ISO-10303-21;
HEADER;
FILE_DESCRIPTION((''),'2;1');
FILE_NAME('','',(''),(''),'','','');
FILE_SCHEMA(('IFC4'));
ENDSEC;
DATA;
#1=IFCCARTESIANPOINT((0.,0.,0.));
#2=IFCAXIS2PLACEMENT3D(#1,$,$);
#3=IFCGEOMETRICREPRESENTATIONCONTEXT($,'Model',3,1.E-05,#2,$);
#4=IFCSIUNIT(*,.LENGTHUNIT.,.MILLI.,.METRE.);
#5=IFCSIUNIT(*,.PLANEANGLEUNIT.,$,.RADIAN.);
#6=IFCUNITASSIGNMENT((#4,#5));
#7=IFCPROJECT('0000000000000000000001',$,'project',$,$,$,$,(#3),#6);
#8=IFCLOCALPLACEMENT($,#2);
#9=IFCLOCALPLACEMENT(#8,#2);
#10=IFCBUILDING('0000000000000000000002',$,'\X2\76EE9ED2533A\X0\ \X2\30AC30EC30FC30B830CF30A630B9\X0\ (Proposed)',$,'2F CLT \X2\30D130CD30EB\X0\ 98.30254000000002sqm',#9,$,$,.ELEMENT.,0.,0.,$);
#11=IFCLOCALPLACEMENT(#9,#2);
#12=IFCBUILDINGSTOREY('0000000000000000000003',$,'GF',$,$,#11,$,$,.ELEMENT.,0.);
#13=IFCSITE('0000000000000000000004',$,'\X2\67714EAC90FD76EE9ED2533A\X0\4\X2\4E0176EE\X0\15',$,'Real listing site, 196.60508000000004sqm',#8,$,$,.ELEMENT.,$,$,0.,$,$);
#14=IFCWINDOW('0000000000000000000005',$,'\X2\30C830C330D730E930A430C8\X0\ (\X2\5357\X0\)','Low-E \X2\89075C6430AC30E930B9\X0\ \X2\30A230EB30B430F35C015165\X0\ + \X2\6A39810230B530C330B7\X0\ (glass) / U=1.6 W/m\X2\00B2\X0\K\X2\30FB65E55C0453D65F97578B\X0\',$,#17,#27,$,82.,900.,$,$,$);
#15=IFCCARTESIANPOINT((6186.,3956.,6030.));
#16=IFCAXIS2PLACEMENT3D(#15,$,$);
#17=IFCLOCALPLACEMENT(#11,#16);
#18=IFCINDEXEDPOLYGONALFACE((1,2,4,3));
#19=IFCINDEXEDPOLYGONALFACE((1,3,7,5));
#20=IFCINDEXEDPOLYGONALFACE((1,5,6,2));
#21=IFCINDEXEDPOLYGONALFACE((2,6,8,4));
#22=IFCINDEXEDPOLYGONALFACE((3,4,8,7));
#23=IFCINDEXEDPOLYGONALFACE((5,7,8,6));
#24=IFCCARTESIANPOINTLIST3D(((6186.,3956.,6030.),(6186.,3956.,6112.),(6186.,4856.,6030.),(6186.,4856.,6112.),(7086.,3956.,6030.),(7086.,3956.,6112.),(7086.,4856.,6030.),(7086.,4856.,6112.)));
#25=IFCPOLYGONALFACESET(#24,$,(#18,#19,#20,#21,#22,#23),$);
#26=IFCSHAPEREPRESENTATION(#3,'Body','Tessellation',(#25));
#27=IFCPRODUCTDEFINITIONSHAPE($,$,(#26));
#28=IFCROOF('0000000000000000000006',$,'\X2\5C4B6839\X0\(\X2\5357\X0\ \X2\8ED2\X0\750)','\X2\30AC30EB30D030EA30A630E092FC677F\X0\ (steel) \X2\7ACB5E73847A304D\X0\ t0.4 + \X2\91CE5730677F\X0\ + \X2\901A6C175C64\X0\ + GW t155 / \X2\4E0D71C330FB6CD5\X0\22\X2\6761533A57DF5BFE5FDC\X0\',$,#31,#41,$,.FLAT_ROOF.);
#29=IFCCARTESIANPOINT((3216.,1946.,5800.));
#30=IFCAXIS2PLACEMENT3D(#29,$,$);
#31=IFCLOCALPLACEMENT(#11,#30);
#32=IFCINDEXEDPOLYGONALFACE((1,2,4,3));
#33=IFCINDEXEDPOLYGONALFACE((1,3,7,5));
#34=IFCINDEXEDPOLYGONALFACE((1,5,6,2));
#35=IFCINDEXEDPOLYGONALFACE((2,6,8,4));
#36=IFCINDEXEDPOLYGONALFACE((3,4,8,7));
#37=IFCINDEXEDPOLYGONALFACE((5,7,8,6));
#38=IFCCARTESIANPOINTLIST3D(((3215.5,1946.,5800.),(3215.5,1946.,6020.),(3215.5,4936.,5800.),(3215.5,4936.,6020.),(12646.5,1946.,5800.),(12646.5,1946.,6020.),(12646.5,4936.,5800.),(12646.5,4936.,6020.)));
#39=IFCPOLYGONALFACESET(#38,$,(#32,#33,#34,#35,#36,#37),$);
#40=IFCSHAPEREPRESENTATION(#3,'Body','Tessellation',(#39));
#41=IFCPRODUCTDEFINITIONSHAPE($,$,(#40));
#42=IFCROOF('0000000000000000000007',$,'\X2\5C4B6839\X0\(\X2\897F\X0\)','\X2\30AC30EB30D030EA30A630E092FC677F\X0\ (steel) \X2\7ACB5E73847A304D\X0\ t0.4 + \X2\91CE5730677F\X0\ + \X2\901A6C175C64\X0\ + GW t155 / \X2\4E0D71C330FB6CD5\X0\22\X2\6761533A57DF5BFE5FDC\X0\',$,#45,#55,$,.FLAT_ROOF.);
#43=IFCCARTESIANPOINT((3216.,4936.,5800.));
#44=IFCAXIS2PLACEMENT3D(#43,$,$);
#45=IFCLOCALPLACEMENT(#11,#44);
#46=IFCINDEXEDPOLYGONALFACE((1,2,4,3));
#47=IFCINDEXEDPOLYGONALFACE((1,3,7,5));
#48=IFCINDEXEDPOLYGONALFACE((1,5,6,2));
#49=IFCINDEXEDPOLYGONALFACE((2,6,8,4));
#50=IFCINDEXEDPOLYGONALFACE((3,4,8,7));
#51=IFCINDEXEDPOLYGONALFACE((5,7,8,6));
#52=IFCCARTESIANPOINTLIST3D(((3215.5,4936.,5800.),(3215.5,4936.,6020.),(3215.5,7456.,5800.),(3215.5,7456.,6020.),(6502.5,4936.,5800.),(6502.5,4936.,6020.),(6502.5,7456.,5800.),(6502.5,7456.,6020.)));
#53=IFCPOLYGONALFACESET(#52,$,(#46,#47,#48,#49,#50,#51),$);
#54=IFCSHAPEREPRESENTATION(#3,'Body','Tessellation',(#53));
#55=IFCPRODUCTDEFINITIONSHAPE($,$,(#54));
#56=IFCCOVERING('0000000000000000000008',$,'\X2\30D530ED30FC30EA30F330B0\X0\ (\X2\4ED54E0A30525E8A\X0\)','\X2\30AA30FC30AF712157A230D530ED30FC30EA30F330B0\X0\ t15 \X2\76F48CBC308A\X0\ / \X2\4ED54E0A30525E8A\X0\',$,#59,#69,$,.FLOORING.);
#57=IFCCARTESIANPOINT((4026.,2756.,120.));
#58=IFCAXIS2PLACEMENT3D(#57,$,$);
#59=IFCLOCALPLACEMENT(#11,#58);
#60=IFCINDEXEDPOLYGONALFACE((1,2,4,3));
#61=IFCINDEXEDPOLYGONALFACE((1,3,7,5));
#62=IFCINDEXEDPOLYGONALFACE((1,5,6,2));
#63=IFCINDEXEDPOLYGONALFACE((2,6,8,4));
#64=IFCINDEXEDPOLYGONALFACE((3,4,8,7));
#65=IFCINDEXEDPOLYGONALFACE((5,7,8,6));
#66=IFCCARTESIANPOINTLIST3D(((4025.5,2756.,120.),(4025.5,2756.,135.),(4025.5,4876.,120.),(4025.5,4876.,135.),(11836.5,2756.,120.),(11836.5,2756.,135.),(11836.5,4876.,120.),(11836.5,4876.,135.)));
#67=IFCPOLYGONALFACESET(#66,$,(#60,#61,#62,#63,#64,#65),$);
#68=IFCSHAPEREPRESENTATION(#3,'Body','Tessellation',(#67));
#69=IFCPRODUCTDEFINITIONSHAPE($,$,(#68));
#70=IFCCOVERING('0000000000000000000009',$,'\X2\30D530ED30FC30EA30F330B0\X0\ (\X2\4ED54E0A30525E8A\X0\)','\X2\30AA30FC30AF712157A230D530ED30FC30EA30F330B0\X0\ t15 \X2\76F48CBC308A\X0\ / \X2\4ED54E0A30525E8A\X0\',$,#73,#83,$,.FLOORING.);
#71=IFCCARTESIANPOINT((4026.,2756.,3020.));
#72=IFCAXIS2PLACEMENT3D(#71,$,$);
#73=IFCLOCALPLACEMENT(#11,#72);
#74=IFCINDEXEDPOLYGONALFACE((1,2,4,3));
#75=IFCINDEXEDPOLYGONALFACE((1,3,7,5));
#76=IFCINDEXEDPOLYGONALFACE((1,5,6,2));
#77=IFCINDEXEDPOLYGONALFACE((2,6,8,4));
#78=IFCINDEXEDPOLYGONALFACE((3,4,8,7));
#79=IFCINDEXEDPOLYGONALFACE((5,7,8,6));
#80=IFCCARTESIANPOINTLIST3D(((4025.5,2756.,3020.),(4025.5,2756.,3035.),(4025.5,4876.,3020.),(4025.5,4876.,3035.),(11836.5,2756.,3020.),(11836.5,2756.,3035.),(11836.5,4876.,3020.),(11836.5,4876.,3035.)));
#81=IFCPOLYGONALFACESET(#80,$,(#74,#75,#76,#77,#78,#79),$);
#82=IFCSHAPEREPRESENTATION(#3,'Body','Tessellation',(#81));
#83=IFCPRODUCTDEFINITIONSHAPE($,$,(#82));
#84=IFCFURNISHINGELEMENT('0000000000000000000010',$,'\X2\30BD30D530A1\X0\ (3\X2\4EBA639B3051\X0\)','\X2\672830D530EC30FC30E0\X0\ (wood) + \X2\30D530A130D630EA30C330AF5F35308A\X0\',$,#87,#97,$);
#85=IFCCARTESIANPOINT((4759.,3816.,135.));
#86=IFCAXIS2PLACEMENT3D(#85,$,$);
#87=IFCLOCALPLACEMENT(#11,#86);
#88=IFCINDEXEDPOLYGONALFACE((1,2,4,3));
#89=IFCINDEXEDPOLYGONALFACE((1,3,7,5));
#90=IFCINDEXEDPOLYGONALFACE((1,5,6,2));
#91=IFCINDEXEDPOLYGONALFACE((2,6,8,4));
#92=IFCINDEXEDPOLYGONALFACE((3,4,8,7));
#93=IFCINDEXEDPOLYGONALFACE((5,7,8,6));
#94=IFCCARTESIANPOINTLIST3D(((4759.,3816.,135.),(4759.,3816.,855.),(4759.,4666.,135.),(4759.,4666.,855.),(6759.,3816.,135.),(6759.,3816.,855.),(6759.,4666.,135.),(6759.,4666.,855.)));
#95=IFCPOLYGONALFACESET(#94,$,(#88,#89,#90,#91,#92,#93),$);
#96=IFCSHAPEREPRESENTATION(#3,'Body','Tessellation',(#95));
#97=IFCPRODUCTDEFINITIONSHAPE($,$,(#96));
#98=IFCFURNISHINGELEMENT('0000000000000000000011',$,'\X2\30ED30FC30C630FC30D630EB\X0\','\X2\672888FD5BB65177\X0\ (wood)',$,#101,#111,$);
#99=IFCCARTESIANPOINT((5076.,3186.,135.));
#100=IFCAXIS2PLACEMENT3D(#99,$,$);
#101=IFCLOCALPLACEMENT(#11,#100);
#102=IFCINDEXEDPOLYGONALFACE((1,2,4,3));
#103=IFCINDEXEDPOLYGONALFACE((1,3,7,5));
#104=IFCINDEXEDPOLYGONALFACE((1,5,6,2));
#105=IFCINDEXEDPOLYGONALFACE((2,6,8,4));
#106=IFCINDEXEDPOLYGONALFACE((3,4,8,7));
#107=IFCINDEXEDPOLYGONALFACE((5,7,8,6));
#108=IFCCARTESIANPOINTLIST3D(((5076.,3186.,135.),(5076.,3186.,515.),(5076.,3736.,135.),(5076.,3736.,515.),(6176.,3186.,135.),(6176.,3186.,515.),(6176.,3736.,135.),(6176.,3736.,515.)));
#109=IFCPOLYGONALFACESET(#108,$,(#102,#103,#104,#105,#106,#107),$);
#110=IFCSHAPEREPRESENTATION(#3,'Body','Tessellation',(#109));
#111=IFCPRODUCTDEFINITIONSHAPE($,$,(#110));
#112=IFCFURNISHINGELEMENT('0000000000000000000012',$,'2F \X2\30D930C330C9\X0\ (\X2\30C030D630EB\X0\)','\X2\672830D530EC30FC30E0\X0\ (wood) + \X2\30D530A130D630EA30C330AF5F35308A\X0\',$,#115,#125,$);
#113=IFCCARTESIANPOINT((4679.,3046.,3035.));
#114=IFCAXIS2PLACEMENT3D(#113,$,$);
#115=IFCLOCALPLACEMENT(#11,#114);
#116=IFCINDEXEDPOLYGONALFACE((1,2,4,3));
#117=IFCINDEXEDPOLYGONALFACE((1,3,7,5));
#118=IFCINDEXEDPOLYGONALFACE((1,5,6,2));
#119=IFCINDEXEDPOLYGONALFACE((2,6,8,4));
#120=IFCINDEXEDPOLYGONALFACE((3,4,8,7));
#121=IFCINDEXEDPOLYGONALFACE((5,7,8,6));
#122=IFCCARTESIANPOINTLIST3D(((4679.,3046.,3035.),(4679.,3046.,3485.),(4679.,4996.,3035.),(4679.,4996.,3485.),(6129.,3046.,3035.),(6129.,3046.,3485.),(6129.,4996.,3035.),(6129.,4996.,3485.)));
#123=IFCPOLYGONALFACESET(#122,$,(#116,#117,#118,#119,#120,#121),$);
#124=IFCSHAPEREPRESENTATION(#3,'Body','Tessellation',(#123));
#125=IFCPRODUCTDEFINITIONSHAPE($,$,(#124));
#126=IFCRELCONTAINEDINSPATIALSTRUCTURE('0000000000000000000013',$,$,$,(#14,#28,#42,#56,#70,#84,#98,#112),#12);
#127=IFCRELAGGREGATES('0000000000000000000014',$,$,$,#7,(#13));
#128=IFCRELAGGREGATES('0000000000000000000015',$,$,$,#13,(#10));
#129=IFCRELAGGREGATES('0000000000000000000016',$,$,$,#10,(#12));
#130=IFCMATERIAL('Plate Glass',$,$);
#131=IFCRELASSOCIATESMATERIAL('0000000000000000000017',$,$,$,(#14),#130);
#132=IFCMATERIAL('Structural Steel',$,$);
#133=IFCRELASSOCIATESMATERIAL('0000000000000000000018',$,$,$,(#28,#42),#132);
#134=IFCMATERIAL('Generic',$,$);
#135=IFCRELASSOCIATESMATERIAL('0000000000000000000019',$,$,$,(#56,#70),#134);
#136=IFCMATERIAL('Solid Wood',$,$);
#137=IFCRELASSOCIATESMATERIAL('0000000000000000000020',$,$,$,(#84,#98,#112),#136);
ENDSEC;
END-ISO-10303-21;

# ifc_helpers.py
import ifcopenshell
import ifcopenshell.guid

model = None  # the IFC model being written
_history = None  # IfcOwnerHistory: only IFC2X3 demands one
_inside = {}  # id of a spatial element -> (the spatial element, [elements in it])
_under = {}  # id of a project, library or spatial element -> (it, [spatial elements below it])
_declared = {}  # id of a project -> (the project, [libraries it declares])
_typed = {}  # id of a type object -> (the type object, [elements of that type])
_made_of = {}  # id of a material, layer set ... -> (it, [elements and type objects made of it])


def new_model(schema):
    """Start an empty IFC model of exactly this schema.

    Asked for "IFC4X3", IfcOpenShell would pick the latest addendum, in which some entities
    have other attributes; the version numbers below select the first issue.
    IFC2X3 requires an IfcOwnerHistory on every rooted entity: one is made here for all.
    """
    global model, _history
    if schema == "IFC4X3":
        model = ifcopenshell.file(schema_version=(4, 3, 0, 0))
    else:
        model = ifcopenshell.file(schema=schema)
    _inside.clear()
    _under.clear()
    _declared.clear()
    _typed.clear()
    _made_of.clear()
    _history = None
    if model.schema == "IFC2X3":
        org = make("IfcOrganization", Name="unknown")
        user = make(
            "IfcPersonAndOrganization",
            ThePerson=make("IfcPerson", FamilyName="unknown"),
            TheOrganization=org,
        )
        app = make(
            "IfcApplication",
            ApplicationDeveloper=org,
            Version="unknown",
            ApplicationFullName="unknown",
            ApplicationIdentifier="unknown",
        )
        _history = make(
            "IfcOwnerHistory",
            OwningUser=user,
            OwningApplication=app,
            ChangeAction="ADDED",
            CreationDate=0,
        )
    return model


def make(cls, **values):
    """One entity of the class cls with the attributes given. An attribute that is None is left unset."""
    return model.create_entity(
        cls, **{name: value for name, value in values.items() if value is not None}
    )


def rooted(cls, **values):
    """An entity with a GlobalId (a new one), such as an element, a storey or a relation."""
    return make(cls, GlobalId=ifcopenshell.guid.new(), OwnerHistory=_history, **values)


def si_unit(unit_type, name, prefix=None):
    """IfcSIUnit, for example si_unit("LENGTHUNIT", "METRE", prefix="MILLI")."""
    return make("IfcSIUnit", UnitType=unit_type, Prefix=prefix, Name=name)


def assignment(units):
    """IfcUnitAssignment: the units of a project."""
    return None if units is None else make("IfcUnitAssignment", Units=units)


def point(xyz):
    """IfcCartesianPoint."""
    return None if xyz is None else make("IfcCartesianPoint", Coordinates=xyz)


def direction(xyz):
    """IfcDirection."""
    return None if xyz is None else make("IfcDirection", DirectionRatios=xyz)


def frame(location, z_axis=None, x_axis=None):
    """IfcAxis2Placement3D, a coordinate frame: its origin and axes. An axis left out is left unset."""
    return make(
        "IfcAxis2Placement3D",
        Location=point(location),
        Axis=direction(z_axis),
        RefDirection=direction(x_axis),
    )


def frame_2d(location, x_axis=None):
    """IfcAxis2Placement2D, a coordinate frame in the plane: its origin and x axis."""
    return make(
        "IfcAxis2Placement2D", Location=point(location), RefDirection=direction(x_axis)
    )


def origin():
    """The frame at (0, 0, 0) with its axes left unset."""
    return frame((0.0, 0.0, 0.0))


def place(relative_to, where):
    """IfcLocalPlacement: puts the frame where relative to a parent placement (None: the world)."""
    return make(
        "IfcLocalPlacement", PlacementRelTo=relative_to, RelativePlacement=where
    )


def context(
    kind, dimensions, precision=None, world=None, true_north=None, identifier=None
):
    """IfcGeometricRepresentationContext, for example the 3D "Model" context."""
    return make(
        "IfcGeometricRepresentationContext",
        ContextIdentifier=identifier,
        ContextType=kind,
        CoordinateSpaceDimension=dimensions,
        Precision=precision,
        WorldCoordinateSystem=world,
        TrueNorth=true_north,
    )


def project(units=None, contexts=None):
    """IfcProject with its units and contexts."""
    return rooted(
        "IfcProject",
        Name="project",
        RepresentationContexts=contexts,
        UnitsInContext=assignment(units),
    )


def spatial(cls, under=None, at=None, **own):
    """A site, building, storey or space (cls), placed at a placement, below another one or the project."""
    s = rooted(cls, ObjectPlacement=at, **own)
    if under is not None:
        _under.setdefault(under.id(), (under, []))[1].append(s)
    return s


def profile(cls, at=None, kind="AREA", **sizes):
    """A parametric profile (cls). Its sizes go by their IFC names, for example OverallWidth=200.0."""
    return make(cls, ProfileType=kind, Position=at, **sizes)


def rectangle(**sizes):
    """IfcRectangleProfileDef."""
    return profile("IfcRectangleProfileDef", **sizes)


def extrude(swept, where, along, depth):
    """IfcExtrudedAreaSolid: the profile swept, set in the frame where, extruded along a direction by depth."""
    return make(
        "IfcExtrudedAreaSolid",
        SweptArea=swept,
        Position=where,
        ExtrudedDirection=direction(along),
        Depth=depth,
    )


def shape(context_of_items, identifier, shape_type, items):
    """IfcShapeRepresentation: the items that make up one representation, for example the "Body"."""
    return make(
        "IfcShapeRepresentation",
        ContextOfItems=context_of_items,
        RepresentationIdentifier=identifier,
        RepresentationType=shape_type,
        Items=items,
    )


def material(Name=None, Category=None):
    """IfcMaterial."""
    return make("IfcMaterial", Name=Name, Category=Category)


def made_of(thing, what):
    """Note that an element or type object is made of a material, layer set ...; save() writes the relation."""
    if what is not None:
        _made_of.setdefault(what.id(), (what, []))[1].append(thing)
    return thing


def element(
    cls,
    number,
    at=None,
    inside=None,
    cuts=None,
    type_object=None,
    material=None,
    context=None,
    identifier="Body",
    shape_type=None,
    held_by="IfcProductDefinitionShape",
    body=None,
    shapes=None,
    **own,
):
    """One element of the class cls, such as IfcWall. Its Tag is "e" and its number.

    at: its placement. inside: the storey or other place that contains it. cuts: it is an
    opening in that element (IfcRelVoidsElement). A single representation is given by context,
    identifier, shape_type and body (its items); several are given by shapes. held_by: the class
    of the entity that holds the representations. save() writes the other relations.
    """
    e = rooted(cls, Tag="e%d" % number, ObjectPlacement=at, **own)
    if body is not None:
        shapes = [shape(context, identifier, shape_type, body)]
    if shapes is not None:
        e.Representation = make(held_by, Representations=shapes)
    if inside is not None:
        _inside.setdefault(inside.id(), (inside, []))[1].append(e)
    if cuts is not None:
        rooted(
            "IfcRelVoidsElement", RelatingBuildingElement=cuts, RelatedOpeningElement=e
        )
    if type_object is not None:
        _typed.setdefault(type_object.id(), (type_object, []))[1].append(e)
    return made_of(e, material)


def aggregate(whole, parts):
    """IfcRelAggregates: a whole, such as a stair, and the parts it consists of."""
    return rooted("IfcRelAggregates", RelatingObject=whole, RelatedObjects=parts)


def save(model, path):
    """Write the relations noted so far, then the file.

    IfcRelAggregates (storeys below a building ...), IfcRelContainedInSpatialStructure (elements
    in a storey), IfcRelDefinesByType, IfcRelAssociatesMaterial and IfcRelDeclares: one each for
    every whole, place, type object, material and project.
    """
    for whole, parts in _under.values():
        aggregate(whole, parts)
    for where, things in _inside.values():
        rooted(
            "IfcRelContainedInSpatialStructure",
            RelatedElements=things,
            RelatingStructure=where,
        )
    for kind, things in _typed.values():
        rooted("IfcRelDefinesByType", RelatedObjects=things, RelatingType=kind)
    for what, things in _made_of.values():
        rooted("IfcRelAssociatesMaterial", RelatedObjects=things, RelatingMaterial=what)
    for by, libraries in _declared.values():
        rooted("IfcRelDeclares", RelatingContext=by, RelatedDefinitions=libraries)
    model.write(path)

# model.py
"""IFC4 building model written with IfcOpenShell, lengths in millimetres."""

from ifc_helpers import new_model, si_unit, frame, frame_2d, origin, place, context, project, spatial, rectangle, extrude, material, element, save


model = new_model("IFC4")

# Units and contexts
model_context = context("Model", 3, precision=1e-05, world=origin())
ifc_project = project(units=[si_unit("LENGTHUNIT", "METRE", prefix="MILLI"), si_unit("PLANEANGLEUNIT", "RADIAN")], contexts=[model_context])

# Site, building, storey
site_placement = place(None, origin())
site = spatial("IfcSite", under=ifc_project, at=site_placement, Name="東京都目黒区4丁目15", ObjectType="Real listing site, 196.60508000000004sqm", CompositionType="ELEMENT", RefElevation=0.0)
building_placement = place(site_placement, origin())
building = spatial("IfcBuilding", under=site, at=building_placement, Name="目黒区 ガレージハウス (Proposed)", ObjectType="2F CLT パネル 98.30254000000002sqm", CompositionType="ELEMENT", ElevationOfRefHeight=0.0, ElevationOfTerrain=0.0)
storey_placement = place(building_placement, origin())
storey = spatial("IfcBuildingStorey", under=building, at=storey_placement, Name="GF", CompositionType="ELEMENT", Elevation=0.0)

# Shared definitions
ifc_material_1 = material(Name="Solid Wood")

# Shared definitions
ifc_material_2 = material(Name="Plate Glass")

# Window
window_1_placement = place(storey_placement, frame((6186.0, 3956.0, 6030.0)))
element("IfcWindow", 1, at=window_1_placement, inside=storey, material=ifc_material_2, Name="トップライト (南)", Description="Low-E 複層ガラス アルゴン封入 + 樹脂サッシ (glass) / U=1.6 W/m²K・日射取得型", OverallHeight=82.0, OverallWidth=900.0, context=model_context, shape_type="SweptSolid", body=[
    extrude(rectangle(XDim=900.0, YDim=900.0, at=frame_2d((450.0, 450.0))), frame((6186.0, 3956.0, 6030.0)), (0.0, 0.0, 1.0), 82.0),
])

# Roofs
ifc_material_3 = material(Name="Structural Steel")
roof_1_placement = place(storey_placement, frame((3216.0, 1946.0, 5800.0)))
element("IfcRoof", 2, at=roof_1_placement, inside=storey, material=ifc_material_3, Name="屋根(南 軒750)", Description="ガルバリウム鋼板 (steel) 立平葺き t0.4 + 野地板 + 通気層 + GW t155 / 不燃・法22条区域対応", PredefinedType="FLAT_ROOF", context=model_context, shape_type="SweptSolid", body=[
    extrude(rectangle(XDim=9431.0, YDim=2990.0, at=frame_2d((4715.0, 1495.0))), frame((3216.0, 1946.0, 5800.0)), (0.0, 0.0, 1.0), 220.0),
])
roof_2_placement = place(storey_placement, frame((3216.0, 4936.0, 5800.0)))
element("IfcRoof", 3, at=roof_2_placement, inside=storey, material=ifc_material_3, Name="屋根(西)", Description="ガルバリウム鋼板 (steel) 立平葺き t0.4 + 野地板 + 通気層 + GW t155 / 不燃・法22条区域対応", PredefinedType="FLAT_ROOF", context=model_context, shape_type="SweptSolid", body=[
    extrude(rectangle(XDim=3287.0, YDim=2520.0, at=frame_2d((1643.0, 1260.0))), frame((3216.0, 4936.0, 5800.0)), (0.0, 0.0, 1.0), 220.0),
])

# Coverings
ifc_material_4 = material(Name="Generic")
covering_1_placement = place(storey_placement, frame((4026.0, 2756.0, 120.0)))
element("IfcCovering", 4, at=covering_1_placement, inside=storey, material=ifc_material_4, Name="フローリング (仕上げ床)", Description="オーク無垢フローリング t15 直貼り / 仕上げ床", PredefinedType="FLOORING", context=model_context, shape_type="SweptSolid", body=[
    extrude(rectangle(XDim=7811.0, YDim=2120.0, at=frame_2d((3905.0, 1060.0))), frame((4026.0, 2756.0, 120.0)), (0.0, 0.0, 1.0), 15.0),
])
covering_2_placement = place(storey_placement, frame((4026.0, 2756.0, 3020.0)))
element("IfcCovering", 5, at=covering_2_placement, inside=storey, material=ifc_material_4, Name="フローリング (仕上げ床)", Description="オーク無垢フローリング t15 直貼り / 仕上げ床", PredefinedType="FLOORING", context=model_context, shape_type="SweptSolid", body=[
    extrude(rectangle(XDim=7811.0, YDim=2120.0, at=frame_2d((3905.0, 1060.0))), frame((4026.0, 2756.0, 3020.0)), (0.0, 0.0, 1.0), 15.0),
])

# Furnishing elements
furnishing_1_placement = place(storey_placement, frame((4759.0, 3816.0, 135.0)))
element("IfcFurnishingElement", 6, at=furnishing_1_placement, inside=storey, material=ifc_material_1, Name="ソファ (3人掛け)", Description="木フレーム (wood) + ファブリック張り", context=model_context, shape_type="SweptSolid", body=[
    extrude(rectangle(XDim=2000.0, YDim=850.0, at=frame_2d((1000.0, 425.0))), frame((4759.0, 3816.0, 135.0)), (0.0, 0.0, 1.0), 720.0),
])
furnishing_2_placement = place(storey_placement, frame((5076.0, 3186.0, 135.0)))
element("IfcFurnishingElement", 7, at=furnishing_2_placement, inside=storey, material=ifc_material_1, Name="ローテーブル", Description="木製家具 (wood)", context=model_context, shape_type="SweptSolid", body=[
    extrude(rectangle(XDim=1100.0, YDim=550.0, at=frame_2d((550.0, 275.0))), frame((5076.0, 3186.0, 135.0)), (0.0, 0.0, 1.0), 380.0),
])
furnishing_3_placement = place(storey_placement, frame((4679.0, 3046.0, 3035.0)))
element("IfcFurnishingElement", 8, at=furnishing_3_placement, inside=storey, material=ifc_material_1, Name="2F ベッド (ダブル)", Description="木フレーム (wood) + ファブリック張り", context=model_context, shape_type="SweptSolid", body=[
    extrude(rectangle(XDim=1450.0, YDim=1950.0, at=frame_2d((725.0, 975.0))), frame((4679.0, 3046.0, 3035.0)), (0.0, 0.0, 1.0), 450.0),
])

save(model, "model.ifc")
